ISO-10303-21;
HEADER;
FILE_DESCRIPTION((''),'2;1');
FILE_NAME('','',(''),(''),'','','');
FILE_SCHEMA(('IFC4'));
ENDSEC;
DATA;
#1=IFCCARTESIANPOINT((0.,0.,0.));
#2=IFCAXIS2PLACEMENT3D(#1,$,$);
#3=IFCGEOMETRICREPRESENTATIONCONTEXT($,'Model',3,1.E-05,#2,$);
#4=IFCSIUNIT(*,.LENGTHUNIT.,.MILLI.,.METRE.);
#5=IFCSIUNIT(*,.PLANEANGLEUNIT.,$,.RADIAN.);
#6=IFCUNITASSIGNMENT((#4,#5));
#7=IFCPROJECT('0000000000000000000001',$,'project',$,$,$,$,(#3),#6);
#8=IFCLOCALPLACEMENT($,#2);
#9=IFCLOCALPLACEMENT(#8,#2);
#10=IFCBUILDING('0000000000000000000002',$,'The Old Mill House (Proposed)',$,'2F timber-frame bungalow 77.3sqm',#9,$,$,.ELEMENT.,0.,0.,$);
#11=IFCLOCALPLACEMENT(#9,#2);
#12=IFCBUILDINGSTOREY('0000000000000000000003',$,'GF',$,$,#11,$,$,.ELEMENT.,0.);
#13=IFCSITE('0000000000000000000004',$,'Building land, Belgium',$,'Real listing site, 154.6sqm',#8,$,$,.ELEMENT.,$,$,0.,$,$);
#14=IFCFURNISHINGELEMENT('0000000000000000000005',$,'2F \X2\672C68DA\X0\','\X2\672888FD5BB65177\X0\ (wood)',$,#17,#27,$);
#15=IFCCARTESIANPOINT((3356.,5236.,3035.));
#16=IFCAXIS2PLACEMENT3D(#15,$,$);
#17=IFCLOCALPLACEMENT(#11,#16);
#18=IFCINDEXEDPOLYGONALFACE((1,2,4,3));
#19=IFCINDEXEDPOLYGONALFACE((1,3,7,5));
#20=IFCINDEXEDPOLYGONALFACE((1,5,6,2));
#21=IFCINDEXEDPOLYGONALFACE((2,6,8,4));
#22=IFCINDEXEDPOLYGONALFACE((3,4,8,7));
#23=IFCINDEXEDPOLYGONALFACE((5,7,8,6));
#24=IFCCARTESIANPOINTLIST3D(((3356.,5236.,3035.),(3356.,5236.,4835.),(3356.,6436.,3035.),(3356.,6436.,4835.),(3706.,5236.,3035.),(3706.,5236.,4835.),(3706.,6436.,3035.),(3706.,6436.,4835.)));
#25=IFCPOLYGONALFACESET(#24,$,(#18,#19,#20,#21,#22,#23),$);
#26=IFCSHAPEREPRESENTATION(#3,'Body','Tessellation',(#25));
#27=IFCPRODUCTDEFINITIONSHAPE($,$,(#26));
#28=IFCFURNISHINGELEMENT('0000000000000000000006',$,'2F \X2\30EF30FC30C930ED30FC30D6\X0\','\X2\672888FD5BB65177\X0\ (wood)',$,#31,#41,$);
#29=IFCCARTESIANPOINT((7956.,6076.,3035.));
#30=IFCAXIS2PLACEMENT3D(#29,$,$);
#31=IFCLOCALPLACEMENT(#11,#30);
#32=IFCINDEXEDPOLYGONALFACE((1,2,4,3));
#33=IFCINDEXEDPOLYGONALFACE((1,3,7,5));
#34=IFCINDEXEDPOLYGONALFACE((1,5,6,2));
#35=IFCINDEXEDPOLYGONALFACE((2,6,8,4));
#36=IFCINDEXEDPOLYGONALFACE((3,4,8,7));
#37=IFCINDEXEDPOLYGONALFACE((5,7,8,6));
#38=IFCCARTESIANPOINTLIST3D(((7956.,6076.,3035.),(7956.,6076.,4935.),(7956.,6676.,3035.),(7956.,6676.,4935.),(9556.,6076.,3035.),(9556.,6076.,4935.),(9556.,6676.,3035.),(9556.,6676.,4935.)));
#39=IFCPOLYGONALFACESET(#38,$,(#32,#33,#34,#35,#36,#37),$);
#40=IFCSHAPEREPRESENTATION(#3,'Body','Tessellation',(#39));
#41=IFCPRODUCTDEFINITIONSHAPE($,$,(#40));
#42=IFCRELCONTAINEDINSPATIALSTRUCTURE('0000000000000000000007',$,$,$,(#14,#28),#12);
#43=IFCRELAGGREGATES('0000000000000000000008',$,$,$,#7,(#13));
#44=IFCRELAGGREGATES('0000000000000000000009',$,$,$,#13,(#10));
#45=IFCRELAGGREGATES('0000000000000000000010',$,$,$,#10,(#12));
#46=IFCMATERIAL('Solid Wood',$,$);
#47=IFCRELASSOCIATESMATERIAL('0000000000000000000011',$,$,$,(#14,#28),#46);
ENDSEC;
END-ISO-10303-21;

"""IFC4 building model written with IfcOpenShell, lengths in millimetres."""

from ifc_helpers import new_model, si_unit, frame, frame_2d, origin, place, context, project, spatial, rectangle, extrude, material, element, save


model = new_model("IFC4")

# Units and contexts
model_context = context("Model", 3, precision=1e-05, world=origin())
ifc_project = project(units=[si_unit("LENGTHUNIT", "METRE", prefix="MILLI"), si_unit("PLANEANGLEUNIT", "RADIAN")], contexts=[model_context])

# Site, building, storey
site_placement = place(None, origin())
site = spatial("IfcSite", under=ifc_project, at=site_placement, Name="Building land, Belgium", ObjectType="Real listing site, 154.6sqm", CompositionType="ELEMENT", RefElevation=0.0)
building_placement = place(site_placement, origin())
building = spatial("IfcBuilding", under=site, at=building_placement, Name="The Old Mill House (Proposed)", ObjectType="2F timber-frame bungalow 77.3sqm", CompositionType="ELEMENT", ElevationOfRefHeight=0.0, ElevationOfTerrain=0.0)
storey_placement = place(building_placement, origin())
storey = spatial("IfcBuildingStorey", under=building, at=storey_placement, Name="GF", CompositionType="ELEMENT", Elevation=0.0)

# Shared definitions
ifc_material_1 = material(Name="Solid Wood")

# Furnishing elements
furnishing_1_placement = place(storey_placement, frame((3356.0, 5236.0, 3035.0)))
element("IfcFurnishingElement", 1, at=furnishing_1_placement, inside=storey, material=ifc_material_1, Name="2F 本棚", Description="木製家具 (wood)", context=model_context, shape_type="SweptSolid", body=[
    extrude(rectangle(XDim=350.0, YDim=1200.0, at=frame_2d((175.0, 600.0))), frame((3356.0, 5236.0, 3035.0)), (0.0, 0.0, 1.0), 1800.0),
])
furnishing_2_placement = place(storey_placement, frame((7956.0, 6076.0, 3035.0)))
element("IfcFurnishingElement", 2, at=furnishing_2_placement, inside=storey, material=ifc_material_1, Name="2F ワードローブ", Description="木製家具 (wood)", context=model_context, shape_type="SweptSolid", body=[
    extrude(rectangle(XDim=1600.0, YDim=600.0, at=frame_2d((800.0, 300.0))), frame((7956.0, 6076.0, 3035.0)), (0.0, 0.0, 1.0), 1900.0),
])

save(model, "model.ifc")
